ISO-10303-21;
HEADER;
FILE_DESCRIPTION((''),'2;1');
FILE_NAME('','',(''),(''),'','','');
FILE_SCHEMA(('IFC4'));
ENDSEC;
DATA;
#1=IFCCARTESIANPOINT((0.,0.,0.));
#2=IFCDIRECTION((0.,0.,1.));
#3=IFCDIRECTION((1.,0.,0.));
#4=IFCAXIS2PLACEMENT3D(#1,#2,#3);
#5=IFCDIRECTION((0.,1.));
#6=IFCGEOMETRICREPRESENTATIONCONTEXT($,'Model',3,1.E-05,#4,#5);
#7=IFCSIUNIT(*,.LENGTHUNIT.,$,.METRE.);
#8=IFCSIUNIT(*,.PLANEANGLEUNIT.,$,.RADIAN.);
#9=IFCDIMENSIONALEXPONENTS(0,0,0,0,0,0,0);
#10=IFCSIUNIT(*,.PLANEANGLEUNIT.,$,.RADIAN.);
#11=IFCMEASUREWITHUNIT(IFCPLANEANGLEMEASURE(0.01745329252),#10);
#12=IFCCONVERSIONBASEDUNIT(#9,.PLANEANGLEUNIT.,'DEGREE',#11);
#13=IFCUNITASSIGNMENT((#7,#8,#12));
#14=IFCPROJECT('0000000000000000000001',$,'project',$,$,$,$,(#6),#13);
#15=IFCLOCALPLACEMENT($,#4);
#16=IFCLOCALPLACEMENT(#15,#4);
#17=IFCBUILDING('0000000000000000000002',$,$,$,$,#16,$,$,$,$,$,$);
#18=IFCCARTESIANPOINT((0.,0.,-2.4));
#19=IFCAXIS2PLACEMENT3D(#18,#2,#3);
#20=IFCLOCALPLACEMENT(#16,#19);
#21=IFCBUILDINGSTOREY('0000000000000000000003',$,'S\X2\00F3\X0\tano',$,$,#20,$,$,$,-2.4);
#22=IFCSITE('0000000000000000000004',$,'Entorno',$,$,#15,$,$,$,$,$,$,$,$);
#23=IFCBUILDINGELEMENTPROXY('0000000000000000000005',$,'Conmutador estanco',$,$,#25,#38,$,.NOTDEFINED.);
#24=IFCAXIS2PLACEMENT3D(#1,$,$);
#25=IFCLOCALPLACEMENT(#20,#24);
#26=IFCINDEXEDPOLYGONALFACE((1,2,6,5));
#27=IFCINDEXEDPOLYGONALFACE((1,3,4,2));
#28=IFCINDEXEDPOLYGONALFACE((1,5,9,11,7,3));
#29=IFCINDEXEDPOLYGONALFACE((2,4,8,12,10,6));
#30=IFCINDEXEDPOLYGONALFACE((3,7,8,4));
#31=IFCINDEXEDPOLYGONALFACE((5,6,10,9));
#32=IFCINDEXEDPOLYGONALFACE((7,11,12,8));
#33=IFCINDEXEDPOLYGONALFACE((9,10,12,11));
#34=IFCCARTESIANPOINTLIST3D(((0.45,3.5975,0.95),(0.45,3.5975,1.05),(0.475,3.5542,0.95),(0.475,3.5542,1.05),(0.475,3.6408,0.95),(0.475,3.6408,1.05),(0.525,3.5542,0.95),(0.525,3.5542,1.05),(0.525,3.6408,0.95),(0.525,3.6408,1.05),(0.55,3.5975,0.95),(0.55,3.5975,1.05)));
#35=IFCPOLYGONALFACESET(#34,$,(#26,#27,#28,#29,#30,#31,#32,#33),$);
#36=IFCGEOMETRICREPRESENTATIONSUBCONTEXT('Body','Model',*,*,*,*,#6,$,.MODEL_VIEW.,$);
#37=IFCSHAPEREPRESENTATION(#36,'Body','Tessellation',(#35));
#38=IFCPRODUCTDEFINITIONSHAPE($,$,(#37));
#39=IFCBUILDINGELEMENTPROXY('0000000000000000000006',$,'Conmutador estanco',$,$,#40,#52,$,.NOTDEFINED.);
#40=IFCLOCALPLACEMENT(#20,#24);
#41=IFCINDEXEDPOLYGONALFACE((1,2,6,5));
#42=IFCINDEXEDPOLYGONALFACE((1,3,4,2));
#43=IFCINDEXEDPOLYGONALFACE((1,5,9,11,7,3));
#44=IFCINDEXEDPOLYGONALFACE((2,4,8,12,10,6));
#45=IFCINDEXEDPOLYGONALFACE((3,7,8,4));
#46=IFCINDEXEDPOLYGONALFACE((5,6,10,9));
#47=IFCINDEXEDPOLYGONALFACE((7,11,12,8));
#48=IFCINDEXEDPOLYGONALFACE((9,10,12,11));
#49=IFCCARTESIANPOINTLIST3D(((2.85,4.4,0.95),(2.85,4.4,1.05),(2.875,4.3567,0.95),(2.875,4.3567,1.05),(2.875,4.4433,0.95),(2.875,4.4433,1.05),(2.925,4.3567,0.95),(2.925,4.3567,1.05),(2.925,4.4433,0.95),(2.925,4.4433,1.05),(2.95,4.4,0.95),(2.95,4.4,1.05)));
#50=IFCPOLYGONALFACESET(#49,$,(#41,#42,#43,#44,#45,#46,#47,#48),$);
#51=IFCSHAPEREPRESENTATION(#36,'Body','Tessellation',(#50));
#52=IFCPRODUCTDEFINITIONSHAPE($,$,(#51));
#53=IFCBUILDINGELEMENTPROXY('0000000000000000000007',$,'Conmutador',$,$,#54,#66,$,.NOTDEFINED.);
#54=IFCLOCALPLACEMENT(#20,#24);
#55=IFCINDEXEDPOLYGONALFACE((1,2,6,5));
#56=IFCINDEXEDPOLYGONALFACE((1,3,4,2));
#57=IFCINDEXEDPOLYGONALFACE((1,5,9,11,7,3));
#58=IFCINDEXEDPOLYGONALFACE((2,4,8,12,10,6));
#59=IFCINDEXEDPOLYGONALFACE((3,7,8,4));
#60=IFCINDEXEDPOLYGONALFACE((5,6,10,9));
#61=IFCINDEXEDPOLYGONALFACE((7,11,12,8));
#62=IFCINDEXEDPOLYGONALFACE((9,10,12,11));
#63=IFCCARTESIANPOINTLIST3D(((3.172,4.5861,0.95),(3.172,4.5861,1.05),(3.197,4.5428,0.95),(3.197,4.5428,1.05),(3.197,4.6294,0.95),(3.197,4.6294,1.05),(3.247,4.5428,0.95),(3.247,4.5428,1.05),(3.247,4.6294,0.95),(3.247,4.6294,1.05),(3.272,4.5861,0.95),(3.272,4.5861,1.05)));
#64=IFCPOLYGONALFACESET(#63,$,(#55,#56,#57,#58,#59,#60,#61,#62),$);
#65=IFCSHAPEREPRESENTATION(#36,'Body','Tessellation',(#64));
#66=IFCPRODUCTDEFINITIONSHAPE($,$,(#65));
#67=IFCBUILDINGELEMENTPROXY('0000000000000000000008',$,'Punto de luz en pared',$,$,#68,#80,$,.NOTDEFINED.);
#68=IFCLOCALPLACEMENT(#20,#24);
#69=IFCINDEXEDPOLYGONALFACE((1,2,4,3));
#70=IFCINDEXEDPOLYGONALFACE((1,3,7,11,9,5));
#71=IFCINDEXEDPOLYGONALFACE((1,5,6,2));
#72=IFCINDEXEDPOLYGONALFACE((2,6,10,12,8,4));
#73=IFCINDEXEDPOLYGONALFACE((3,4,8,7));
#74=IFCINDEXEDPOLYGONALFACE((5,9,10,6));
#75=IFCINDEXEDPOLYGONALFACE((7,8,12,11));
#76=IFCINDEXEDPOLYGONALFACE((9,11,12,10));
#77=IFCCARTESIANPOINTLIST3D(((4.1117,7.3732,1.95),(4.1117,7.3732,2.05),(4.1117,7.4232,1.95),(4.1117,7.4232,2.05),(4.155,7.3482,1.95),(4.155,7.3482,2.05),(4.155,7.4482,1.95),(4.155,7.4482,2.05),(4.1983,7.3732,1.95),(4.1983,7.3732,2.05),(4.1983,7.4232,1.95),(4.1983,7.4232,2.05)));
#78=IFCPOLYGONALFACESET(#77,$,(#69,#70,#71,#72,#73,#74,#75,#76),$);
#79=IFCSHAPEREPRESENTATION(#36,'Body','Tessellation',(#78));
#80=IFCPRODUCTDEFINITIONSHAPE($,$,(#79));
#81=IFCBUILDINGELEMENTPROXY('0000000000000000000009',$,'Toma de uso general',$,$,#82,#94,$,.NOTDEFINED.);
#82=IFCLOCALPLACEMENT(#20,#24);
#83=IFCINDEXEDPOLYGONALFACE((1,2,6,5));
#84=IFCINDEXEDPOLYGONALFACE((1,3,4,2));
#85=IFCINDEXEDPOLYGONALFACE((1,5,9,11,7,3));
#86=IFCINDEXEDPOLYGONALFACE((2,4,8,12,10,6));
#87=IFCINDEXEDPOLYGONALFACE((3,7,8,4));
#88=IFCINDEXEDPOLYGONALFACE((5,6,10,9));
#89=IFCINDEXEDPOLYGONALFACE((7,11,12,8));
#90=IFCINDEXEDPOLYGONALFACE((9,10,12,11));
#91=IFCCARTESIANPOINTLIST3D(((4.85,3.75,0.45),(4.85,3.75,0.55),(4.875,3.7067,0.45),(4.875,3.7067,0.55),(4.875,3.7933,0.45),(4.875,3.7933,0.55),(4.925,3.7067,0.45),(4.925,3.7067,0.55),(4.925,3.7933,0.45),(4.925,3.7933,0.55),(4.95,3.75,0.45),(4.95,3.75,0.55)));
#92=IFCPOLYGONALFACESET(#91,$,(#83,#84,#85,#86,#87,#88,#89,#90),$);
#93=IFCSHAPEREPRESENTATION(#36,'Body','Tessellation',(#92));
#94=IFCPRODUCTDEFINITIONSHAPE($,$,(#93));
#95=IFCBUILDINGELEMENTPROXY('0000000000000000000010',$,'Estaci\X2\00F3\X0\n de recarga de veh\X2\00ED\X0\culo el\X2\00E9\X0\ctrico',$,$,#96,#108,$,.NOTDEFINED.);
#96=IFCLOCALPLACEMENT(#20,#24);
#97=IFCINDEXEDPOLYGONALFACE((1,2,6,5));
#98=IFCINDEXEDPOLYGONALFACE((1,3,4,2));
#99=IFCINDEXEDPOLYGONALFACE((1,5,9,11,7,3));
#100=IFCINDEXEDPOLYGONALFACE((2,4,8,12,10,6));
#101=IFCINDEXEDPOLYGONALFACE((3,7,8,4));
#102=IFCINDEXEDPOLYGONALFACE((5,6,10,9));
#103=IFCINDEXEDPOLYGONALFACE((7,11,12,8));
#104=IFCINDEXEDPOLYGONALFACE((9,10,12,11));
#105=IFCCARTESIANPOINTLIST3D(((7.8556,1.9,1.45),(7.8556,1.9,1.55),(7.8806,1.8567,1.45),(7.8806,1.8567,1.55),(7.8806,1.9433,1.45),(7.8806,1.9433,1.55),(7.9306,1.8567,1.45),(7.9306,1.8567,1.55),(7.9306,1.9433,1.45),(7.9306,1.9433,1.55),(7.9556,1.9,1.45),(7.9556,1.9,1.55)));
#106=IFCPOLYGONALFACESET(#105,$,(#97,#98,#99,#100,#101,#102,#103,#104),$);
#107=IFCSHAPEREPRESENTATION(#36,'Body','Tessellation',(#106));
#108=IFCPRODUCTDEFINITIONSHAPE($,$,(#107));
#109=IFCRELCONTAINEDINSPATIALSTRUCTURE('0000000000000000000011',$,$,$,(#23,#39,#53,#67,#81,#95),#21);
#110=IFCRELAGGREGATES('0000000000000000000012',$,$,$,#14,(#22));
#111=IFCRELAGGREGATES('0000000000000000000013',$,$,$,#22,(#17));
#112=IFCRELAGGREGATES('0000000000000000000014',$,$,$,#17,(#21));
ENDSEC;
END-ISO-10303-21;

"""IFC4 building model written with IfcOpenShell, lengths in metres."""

from ifc_helpers import new_model, entity, si_unit, converted_unit, direction, frame, origin_with_axes, place, context, subcontext, project, spatial, polyline, outline, extrude, source, transform, mapped, element, save


model = new_model("IFC4")

# Units and contexts
model_context = context("Model", 3, precision=1e-05, world=origin_with_axes(), true_north=direction((0.0, 1.0)))
body_context = subcontext(model_context, "Body", "Model", "MODEL_VIEW")
ifc_project = project(units=[si_unit("LENGTHUNIT", "METRE"), si_unit("PLANEANGLEUNIT", "RADIAN"), converted_unit("PLANEANGLEUNIT", "DEGREE", entity("IfcPlaneAngleMeasure", 0.01745329252), si_unit("PLANEANGLEUNIT", "RADIAN"), dimensions=[0, 0, 0, 0, 0, 0, 0])], contexts=[model_context])

# Site, building, storey
site_placement = place(None, origin_with_axes())
site = spatial("IfcSite", under=ifc_project, at=site_placement, Name="Entorno")
building_placement = place(site_placement, origin_with_axes())
building = spatial("IfcBuilding", under=site, at=building_placement)
storey_placement = place(building_placement, frame((0.0, 0.0, -2.4), z_axis=(0.0, 0.0, 1.0), x_axis=(1.0, 0.0, 0.0)))
storey = spatial("IfcBuildingStorey", under=building, at=storey_placement, Name="Sótano", Elevation=-2.4)

# Building element proxies
shared_shape_1 = source(origin_with_axes(), body_context, "Body", "SolidModel", [
    extrude(outline(polyline([(0.05, 0.0), (0.025, 0.0433), (-0.025, 0.0433), (-0.05, 0.0), (-0.025, -0.0433), (0.025, -0.0433), (0.05, 0.0)])), frame((0.0, 0.0, -0.05), z_axis=(0.0, 0.0, 1.0), x_axis=(1.0, 0.0, 0.0)), (0.0, 0.0, 1.0), 0.1),
])
proxy_1_placement = place(storey_placement, frame((0.0, 0.0, 2.4), z_axis=(0.0, 0.0, 1.0), x_axis=(1.0, 0.0, 0.0)))
element("IfcBuildingElementProxy", 1, at=proxy_1_placement, inside=storey, Name="Conmutador estanco", PredefinedType="NOTDEFINED", context=body_context, shape_type="Brep", body=[
    mapped(shared_shape_1, transform((0.5, 3.5975, -1.4), x_axis=(1.0, 0.0, 0.0), y_axis=(0.0, 1.0, 0.0), z_axis=(0.0, 0.0, 1.0))),
])
proxy_2_placement = place(storey_placement, frame((0.0, 0.0, 2.4), z_axis=(0.0, 0.0, 1.0), x_axis=(1.0, 0.0, 0.0)))
element("IfcBuildingElementProxy", 2, at=proxy_2_placement, inside=storey, Name="Conmutador estanco", PredefinedType="NOTDEFINED", context=body_context, shape_type="Brep", body=[
    mapped(shared_shape_1, transform((2.9, 4.4, -1.4), x_axis=(1.0, 0.0, 0.0), y_axis=(0.0, 1.0, 0.0), z_axis=(0.0, 0.0, 1.0))),
])
shared_shape_2 = source(origin_with_axes(), body_context, "Body", "SolidModel", [
    extrude(outline(polyline([(0.05, 0.0), (0.025, 0.0433), (-0.025, 0.0433), (-0.05, 0.0), (-0.025, -0.0433), (0.025, -0.0433), (0.05, 0.0)])), frame((0.0, 0.0, -0.05), z_axis=(0.0, 0.0, 1.0), x_axis=(1.0, 0.0, 0.0)), (0.0, 0.0, 1.0), 0.1),
])
proxy_3_placement = place(storey_placement, frame((0.0, 0.0, 2.4), z_axis=(0.0, 0.0, 1.0), x_axis=(1.0, 0.0, 0.0)))
element("IfcBuildingElementProxy", 3, at=proxy_3_placement, inside=storey, Name="Conmutador", PredefinedType="NOTDEFINED", context=body_context, shape_type="Brep", body=[
    mapped(shared_shape_2, transform((3.222, 4.5861, -1.4), x_axis=(1.0, 0.0, 0.0), y_axis=(0.0, 1.0, 0.0), z_axis=(0.0, 0.0, 1.0))),
])
shared_shape_3 = source(origin_with_axes(), body_context, "Body", "SolidModel", [
    extrude(outline(polyline([(0.05, 0.0), (0.025, 0.0433), (-0.025, 0.0433), (-0.05, 0.0), (-0.025, -0.0433), (0.025, -0.0433), (0.05, 0.0)])), frame((0.0, 0.0, -0.05), z_axis=(0.0, 0.0, 1.0), x_axis=(1.0, 0.0, 0.0)), (0.0, 0.0, 1.0), 0.1),
])
proxy_4_placement = place(storey_placement, frame((0.0, 0.0, 2.4), z_axis=(0.0, 0.0, 1.0), x_axis=(1.0, 0.0, 0.0)))
element("IfcBuildingElementProxy", 4, at=proxy_4_placement, inside=storey, Name="Punto de luz en pared", PredefinedType="NOTDEFINED", context=body_context, shape_type="Brep", body=[
    mapped(shared_shape_3, transform((4.155, 7.3982, -0.4), x_axis=(0.0, -1.0, 0.0), y_axis=(1.0, 0.0, 0.0), z_axis=(0.0, 0.0, 1.0))),
])
shared_shape_4 = source(origin_with_axes(), body_context, "Body", "SolidModel", [
    extrude(outline(polyline([(0.05, 0.0), (0.025, 0.0433), (-0.025, 0.0433), (-0.05, 0.0), (-0.025, -0.0433), (0.025, -0.0433), (0.05, 0.0)])), frame((0.0, 0.0, -0.05), z_axis=(0.0, 0.0, 1.0), x_axis=(1.0, 0.0, 0.0)), (0.0, 0.0, 1.0), 0.1),
])
proxy_5_placement = place(storey_placement, frame((0.0, 0.0, 2.4), z_axis=(0.0, 0.0, 1.0), x_axis=(1.0, 0.0, 0.0)))
element("IfcBuildingElementProxy", 5, at=proxy_5_placement, inside=storey, Name="Toma de uso general", PredefinedType="NOTDEFINED", context=body_context, shape_type="Brep", body=[
    mapped(shared_shape_4, transform((4.9, 3.75, -1.9), x_axis=(1.0, 0.0, 0.0), y_axis=(0.0, 1.0, 0.0), z_axis=(0.0, 0.0, 1.0))),
])
shared_shape_5 = source(origin_with_axes(), body_context, "Body", "SolidModel", [
    extrude(outline(polyline([(0.05, 0.0), (0.025, 0.0433), (-0.025, 0.0433), (-0.05, 0.0), (-0.025, -0.0433), (0.025, -0.0433), (0.05, 0.0)])), frame((0.0, 0.0, -0.05), z_axis=(0.0, 0.0, 1.0), x_axis=(1.0, 0.0, 0.0)), (0.0, 0.0, 1.0), 0.1),
])
proxy_6_placement = place(storey_placement, frame((0.0, 0.0, 2.4), z_axis=(0.0, 0.0, 1.0), x_axis=(1.0, 0.0, 0.0)))
element("IfcBuildingElementProxy", 6, at=proxy_6_placement, inside=storey, Name="Estación de recarga de vehículo eléctrico", PredefinedType="NOTDEFINED", context=body_context, shape_type="Brep", body=[
    mapped(shared_shape_5, transform((7.9056, 1.9, -0.9), x_axis=(1.0, 0.0, 0.0), y_axis=(0.0, 1.0, 0.0), z_axis=(0.0, 0.0, 1.0))),
])

save(model, "model.ifc")
